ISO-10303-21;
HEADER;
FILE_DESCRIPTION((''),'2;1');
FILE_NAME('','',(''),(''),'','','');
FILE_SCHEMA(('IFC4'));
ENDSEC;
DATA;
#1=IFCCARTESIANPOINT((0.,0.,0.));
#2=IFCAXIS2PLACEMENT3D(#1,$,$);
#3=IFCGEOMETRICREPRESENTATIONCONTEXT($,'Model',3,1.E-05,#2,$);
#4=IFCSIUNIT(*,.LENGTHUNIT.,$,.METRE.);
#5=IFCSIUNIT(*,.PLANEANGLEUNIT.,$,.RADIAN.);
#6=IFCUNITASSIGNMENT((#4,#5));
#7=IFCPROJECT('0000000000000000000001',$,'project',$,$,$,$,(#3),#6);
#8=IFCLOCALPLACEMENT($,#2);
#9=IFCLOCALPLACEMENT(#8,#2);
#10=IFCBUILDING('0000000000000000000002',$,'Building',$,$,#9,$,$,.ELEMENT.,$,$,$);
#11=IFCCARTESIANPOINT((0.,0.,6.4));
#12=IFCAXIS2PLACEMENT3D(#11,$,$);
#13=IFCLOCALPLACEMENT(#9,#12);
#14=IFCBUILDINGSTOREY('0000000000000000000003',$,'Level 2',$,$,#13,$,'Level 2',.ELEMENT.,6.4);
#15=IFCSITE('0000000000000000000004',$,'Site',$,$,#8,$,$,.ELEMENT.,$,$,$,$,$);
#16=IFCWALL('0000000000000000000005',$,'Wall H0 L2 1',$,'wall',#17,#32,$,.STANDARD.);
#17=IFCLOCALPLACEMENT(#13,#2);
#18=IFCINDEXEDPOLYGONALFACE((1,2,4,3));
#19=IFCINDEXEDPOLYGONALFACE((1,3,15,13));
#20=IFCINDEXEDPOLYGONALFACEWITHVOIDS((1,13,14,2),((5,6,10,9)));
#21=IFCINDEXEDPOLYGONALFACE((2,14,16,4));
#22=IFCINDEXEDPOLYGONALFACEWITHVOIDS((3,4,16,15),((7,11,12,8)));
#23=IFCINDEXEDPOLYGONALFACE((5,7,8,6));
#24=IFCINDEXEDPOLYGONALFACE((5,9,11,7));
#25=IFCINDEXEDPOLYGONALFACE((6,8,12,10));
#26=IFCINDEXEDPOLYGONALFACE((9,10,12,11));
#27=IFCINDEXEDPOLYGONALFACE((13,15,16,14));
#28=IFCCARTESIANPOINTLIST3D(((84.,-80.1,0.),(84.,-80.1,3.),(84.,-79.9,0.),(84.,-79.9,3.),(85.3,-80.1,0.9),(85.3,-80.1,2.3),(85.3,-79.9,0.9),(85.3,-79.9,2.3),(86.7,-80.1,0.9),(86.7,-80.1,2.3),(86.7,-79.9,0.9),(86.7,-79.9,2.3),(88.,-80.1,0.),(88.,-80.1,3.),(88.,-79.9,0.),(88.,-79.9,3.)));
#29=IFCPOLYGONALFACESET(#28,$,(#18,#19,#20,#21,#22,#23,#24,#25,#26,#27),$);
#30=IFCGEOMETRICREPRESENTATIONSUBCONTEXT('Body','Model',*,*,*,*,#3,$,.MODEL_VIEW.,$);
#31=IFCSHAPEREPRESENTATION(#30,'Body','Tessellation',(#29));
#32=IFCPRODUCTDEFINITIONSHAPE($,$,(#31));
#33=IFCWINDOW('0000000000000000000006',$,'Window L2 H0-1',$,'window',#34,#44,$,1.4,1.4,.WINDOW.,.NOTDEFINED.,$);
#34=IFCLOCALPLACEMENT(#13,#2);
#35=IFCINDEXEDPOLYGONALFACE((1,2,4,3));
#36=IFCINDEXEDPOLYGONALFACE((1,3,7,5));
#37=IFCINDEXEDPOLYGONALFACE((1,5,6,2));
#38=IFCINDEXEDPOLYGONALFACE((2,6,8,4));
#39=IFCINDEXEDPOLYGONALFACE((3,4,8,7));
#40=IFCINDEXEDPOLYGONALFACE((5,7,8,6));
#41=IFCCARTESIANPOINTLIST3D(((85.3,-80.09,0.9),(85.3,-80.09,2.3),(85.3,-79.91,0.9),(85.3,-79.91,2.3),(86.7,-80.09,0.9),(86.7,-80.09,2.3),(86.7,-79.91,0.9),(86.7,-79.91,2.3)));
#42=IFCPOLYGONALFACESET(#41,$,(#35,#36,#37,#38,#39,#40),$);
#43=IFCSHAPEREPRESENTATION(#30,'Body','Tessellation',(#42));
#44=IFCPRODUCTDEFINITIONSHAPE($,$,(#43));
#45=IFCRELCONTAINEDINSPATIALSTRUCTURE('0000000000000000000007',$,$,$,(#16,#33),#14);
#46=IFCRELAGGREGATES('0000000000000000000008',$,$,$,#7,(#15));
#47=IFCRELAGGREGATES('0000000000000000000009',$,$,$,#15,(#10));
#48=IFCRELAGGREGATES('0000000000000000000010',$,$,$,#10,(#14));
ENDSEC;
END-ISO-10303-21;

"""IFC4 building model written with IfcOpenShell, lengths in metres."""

from ifc_helpers import new_model, si_unit, frame, frame_2d, origin, origin_2d, place, context, subcontext, project, spatial, rectangle, extrude, element, fill, save


model = new_model("IFC4")

# Units and contexts
model_context = context("Model", 3, precision=1e-05, world=origin())
body_context = subcontext(model_context, "Body", "Model", "MODEL_VIEW")
ifc_project = project(units=[si_unit("LENGTHUNIT", "METRE"), si_unit("PLANEANGLEUNIT", "RADIAN")], contexts=[model_context])

# Site, building, storey
site_placement = place(None, origin())
site = spatial("IfcSite", under=ifc_project, at=site_placement, Name="Site", CompositionType="ELEMENT")
building_placement = place(site_placement, origin())
building = spatial("IfcBuilding", under=site, at=building_placement, Name="Building", CompositionType="ELEMENT")
storey_placement = place(building_placement, frame((0.0, 0.0, 6.4)))
storey = spatial("IfcBuildingStorey", under=building, at=storey_placement, Name="Level 2", LongName="Level 2", CompositionType="ELEMENT", Elevation=6.4)

# Wall, opening, window
wall_1_placement = place(storey_placement, frame((84.0, -80.0, 0.0), z_axis=(0.0, 0.0, 1.0), x_axis=(1.0, 0.0, 0.0)))
wall_1 = element("IfcWall", 1, at=wall_1_placement, inside=storey, Name="Wall H0 L2 1", ObjectType="wall", PredefinedType="STANDARD", context=body_context, shape_type="SweptSolid", body=[
    extrude(rectangle(XDim=4.0, YDim=0.2, at=frame_2d((2.0, 0.0))), origin(), (0.0, 0.0, 1.0), 3.0),
])
opening_placement = place(storey_placement, frame((86.0, -80.0, 0.9), z_axis=(0.0, 0.0, 1.0), x_axis=(1.0, 0.0, 0.0)))
opening = element("IfcOpeningElement", 2, at=opening_placement, cuts=wall_1, ObjectType="Opening", PredefinedType="OPENING", context=body_context, shape_type="SweptSolid", body=[
    extrude(rectangle(XDim=1.4, YDim=0.22, at=origin_2d()), origin(), (0.0, 0.0, 1.0), 1.4),
])
window_placement = place(storey_placement, frame((86.0, -80.0, 0.9), z_axis=(0.0, 0.0, 1.0), x_axis=(1.0, 0.0, 0.0)))
window = element("IfcWindow", 3, at=window_placement, inside=storey, Name="Window L2 H0-1", ObjectType="window", OverallHeight=1.4, OverallWidth=1.4, PartitioningType="NOTDEFINED", PredefinedType="WINDOW", context=body_context, shape_type="SweptSolid", body=[
    extrude(rectangle(XDim=1.4, YDim=0.18, at=origin_2d()), origin(), (0.0, 0.0, 1.0), 1.4),
])
fill(opening, window)

save(model, "model.ifc")
